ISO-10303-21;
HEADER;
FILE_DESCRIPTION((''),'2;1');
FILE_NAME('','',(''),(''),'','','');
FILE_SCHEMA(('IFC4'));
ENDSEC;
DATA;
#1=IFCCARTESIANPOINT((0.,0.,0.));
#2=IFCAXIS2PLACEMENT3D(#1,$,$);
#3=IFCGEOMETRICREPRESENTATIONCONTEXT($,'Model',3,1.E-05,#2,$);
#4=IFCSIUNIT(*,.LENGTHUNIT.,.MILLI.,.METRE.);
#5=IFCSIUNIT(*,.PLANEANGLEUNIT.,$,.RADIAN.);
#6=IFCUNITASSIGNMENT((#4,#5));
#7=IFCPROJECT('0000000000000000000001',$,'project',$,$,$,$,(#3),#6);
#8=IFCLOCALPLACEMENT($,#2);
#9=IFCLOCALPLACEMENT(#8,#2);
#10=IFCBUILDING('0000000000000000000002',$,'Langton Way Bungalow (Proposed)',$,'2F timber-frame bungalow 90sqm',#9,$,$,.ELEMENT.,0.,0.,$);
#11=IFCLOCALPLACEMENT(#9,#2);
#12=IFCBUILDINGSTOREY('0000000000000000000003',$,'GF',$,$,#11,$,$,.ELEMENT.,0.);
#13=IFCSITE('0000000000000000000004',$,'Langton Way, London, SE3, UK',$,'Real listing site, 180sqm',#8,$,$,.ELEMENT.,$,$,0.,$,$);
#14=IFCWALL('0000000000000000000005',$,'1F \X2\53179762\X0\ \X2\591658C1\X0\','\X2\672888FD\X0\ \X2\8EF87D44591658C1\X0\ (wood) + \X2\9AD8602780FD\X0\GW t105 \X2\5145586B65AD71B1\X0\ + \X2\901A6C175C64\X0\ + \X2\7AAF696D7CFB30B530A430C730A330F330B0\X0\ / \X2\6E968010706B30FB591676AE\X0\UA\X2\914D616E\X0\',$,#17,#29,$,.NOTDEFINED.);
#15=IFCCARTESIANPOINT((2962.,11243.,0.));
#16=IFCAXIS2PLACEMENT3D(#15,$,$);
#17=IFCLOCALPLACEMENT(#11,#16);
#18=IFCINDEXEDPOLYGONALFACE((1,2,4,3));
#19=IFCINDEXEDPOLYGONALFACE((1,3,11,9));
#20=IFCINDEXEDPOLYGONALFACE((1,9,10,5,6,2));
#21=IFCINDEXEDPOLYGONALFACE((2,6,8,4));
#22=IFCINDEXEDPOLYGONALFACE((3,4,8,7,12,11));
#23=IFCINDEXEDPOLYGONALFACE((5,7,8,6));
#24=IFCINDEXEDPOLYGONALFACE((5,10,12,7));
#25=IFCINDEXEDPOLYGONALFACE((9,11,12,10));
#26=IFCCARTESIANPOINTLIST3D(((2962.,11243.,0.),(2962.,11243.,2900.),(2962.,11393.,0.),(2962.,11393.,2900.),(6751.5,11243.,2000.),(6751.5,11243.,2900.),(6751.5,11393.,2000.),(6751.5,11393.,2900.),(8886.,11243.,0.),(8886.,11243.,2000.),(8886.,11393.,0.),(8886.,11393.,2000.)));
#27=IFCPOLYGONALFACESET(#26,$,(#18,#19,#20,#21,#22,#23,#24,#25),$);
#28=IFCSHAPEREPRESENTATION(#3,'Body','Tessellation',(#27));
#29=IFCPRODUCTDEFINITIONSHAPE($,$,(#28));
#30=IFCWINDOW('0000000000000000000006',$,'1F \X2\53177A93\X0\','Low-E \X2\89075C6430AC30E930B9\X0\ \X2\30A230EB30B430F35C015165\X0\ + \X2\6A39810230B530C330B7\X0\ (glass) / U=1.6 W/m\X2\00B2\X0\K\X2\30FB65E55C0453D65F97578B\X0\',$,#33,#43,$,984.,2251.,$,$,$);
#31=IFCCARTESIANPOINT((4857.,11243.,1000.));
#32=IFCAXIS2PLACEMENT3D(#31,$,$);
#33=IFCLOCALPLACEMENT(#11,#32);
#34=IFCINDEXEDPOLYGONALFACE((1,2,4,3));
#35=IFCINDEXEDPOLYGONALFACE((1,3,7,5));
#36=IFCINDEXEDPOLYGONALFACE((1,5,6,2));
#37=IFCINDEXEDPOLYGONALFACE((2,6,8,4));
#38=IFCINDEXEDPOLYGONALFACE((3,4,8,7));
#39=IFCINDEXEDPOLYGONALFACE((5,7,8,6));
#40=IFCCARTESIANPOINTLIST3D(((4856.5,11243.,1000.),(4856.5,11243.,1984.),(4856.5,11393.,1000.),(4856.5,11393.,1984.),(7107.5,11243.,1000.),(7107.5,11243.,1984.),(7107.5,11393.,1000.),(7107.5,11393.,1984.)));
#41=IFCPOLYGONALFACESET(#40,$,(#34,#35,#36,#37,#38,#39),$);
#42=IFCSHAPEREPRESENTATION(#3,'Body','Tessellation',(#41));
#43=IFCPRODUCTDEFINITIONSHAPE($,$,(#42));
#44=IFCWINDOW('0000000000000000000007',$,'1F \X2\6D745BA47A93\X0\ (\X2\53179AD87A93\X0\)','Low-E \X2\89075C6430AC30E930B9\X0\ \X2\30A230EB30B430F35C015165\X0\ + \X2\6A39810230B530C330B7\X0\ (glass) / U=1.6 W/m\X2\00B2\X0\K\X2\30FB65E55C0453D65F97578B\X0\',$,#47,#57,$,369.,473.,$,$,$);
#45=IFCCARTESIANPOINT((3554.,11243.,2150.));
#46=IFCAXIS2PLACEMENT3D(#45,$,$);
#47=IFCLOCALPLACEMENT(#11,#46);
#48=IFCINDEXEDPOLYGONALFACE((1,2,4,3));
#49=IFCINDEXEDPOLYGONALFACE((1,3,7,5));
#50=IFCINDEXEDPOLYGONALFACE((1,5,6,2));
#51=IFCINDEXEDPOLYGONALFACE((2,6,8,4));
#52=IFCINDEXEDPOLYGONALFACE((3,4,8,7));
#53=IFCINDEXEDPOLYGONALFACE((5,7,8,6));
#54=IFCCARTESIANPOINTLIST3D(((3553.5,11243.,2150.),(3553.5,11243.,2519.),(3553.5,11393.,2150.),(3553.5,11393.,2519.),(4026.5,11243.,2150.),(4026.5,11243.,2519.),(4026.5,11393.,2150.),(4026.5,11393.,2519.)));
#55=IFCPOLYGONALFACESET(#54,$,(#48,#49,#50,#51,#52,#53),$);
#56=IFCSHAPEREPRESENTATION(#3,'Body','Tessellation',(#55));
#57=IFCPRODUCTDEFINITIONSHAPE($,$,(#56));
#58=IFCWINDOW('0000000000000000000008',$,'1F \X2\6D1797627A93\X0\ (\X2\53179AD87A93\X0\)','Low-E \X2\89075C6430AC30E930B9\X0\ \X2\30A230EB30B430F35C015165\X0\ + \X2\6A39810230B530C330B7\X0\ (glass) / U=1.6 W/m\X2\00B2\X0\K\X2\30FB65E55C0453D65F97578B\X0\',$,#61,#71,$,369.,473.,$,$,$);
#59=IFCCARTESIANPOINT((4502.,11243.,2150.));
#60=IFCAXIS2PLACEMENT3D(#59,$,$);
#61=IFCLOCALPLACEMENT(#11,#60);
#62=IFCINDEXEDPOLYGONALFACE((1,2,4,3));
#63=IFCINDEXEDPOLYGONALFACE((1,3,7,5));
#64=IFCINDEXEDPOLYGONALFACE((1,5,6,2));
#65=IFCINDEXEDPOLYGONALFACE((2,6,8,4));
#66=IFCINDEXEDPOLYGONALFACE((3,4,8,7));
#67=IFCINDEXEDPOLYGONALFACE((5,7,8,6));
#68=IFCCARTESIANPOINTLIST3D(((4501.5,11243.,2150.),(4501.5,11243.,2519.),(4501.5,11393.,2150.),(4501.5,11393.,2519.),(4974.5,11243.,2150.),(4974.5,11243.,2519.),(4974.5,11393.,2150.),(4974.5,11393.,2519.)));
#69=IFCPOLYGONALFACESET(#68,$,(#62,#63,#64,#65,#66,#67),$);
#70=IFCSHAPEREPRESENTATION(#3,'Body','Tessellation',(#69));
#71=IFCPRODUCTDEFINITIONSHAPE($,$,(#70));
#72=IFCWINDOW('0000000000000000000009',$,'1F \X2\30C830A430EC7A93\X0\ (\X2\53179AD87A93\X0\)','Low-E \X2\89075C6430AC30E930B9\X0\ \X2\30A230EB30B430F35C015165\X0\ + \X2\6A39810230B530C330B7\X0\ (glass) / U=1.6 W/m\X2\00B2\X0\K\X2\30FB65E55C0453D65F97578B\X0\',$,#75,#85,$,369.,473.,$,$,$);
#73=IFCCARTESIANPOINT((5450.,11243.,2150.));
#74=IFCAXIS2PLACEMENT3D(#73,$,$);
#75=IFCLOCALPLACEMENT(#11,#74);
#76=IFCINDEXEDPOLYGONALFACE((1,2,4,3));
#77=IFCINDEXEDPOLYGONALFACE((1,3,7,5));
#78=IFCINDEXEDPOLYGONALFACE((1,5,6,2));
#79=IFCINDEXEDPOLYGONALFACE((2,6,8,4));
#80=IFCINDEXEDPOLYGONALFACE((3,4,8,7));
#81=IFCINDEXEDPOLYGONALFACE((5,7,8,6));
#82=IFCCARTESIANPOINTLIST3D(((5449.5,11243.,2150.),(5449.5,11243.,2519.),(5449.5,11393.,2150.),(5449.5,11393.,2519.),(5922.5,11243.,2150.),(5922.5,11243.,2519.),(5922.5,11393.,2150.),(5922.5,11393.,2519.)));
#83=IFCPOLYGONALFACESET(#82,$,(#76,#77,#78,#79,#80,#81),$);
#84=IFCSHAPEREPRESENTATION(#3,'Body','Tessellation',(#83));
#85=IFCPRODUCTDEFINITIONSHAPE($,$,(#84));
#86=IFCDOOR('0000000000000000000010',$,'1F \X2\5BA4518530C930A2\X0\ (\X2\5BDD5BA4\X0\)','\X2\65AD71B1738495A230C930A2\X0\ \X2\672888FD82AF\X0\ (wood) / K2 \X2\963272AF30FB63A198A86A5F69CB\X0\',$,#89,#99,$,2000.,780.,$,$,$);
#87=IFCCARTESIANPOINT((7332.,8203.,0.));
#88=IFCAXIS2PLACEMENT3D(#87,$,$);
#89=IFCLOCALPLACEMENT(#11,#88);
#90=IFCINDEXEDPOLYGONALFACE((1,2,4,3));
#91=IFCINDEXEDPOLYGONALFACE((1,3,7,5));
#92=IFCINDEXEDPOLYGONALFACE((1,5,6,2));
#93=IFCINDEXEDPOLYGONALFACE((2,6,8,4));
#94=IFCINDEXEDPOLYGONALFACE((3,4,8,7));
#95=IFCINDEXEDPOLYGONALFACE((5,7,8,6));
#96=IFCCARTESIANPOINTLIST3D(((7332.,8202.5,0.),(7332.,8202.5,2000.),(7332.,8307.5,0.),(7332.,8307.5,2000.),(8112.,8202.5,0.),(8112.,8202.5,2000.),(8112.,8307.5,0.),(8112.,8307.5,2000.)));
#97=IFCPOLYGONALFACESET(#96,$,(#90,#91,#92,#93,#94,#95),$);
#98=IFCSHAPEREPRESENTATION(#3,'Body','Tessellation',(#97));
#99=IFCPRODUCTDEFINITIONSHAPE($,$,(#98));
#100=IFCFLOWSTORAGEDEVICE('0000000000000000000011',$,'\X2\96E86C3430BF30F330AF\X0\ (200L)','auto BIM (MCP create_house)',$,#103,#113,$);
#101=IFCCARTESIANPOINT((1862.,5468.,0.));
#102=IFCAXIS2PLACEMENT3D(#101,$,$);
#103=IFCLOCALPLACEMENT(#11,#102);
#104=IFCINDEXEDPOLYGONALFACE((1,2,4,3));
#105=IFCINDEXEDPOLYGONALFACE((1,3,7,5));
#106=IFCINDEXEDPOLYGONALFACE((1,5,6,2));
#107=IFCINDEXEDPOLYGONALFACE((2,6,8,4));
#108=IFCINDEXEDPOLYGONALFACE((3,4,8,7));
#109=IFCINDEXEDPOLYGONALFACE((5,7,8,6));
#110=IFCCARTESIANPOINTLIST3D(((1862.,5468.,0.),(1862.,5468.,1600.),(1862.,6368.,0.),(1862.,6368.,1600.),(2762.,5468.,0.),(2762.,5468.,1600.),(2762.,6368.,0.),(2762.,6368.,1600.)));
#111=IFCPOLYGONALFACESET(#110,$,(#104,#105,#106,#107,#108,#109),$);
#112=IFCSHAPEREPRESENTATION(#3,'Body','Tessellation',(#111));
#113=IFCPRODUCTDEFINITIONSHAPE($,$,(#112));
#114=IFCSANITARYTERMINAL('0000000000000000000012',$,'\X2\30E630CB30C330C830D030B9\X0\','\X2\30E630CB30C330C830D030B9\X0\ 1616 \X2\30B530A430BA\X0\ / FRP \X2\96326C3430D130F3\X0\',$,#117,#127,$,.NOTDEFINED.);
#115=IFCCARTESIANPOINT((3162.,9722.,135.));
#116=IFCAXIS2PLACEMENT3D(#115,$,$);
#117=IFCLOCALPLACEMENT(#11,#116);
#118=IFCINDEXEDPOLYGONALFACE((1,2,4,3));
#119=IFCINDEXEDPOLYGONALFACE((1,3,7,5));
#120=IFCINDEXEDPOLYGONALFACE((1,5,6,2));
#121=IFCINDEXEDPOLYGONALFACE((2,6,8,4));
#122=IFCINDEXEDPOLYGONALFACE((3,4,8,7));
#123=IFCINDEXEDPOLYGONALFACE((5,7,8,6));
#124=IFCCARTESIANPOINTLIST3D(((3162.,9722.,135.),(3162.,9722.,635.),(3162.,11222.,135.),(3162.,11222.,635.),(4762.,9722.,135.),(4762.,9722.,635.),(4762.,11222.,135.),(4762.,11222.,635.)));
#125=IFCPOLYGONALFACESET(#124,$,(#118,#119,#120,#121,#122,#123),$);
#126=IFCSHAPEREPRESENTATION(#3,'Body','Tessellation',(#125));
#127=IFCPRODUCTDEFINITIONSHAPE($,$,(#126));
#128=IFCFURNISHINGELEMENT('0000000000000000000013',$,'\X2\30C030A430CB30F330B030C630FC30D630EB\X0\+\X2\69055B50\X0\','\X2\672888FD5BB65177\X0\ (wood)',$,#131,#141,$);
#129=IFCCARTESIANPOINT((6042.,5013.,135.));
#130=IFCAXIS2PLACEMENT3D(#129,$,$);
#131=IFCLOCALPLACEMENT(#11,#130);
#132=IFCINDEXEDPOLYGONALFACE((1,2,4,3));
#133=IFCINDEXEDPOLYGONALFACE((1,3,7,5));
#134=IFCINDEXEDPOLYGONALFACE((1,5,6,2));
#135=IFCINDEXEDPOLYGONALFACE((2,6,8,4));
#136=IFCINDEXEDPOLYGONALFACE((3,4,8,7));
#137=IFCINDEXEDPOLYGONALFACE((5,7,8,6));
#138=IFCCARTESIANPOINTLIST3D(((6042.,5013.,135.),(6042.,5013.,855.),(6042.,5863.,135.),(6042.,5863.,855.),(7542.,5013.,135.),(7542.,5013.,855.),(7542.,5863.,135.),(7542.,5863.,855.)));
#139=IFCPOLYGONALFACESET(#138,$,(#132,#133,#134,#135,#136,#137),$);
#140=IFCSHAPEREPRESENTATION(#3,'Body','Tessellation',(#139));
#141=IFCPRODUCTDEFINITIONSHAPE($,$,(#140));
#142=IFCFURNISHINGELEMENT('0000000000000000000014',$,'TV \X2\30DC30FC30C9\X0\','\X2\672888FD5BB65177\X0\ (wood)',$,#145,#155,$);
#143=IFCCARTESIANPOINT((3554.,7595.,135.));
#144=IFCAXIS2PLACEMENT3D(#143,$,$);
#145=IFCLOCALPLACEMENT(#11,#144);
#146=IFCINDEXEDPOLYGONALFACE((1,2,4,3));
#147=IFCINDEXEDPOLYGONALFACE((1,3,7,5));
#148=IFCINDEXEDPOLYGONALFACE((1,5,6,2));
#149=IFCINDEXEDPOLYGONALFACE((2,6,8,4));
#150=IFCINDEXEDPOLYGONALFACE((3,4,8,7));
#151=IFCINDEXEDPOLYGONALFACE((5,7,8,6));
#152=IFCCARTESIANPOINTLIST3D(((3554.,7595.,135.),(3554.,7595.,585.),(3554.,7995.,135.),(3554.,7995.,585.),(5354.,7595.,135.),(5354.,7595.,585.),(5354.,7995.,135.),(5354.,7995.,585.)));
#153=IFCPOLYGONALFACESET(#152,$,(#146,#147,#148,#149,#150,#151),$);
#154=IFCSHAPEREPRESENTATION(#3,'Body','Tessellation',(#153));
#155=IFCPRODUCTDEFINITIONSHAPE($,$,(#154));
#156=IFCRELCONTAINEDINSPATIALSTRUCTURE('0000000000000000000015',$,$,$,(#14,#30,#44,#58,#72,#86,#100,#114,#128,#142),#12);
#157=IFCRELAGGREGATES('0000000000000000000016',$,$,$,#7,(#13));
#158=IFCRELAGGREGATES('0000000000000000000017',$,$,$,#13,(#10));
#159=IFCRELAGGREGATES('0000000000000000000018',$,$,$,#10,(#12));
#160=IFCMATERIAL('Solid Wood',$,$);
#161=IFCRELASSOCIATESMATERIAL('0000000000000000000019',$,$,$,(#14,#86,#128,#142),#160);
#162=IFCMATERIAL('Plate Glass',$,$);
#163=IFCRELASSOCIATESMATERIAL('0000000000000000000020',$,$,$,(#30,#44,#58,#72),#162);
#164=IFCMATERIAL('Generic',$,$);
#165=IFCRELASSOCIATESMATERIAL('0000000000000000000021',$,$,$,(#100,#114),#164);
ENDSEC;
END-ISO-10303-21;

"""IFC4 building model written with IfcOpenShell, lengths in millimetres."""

from ifc_helpers import new_model, si_unit, frame, frame_2d, origin, place, context, project, spatial, rectangle, extrude, material, element, fill, save


model = new_model("IFC4")

# Units and contexts
model_context = context("Model", 3, precision=1e-05, world=origin())
ifc_project = project(units=[si_unit("LENGTHUNIT", "METRE", prefix="MILLI"), si_unit("PLANEANGLEUNIT", "RADIAN")], contexts=[model_context])

# Site, building, storey
site_placement = place(None, origin())
site = spatial("IfcSite", under=ifc_project, at=site_placement, Name="Langton Way, London, SE3, UK", ObjectType="Real listing site, 180sqm", CompositionType="ELEMENT", RefElevation=0.0)
building_placement = place(site_placement, origin())
building = spatial("IfcBuilding", under=site, at=building_placement, Name="Langton Way Bungalow (Proposed)", ObjectType="2F timber-frame bungalow 90sqm", CompositionType="ELEMENT", ElevationOfRefHeight=0.0, ElevationOfTerrain=0.0)
storey_placement = place(building_placement, origin())
storey = spatial("IfcBuildingStorey", under=building, at=storey_placement, Name="GF", CompositionType="ELEMENT", Elevation=0.0)

# Wall, openings, windows
ifc_material_1 = material(Name="Solid Wood")
wall_1_placement = place(storey_placement, frame((2962.0, 11243.0, 0.0)))
wall_1 = element("IfcWall", 1, at=wall_1_placement, inside=storey, material=ifc_material_1, Name="1F 北面 外壁", Description="木製 軸組外壁 (wood) + 高性能GW t105 充填断熱 + 通気層 + 窯業系サイディング / 準耐火・外皮UA配慮", PredefinedType="NOTDEFINED", context=model_context, shape_type="SweptSolid", body=[
    extrude(rectangle(XDim=5924.0, YDim=150.0, at=frame_2d((2962.0, 75.0))), frame((2962.0, 11243.0, 0.0)), (0.0, 0.0, 1.0), 2900.0),
])
opening_1_placement = place(storey_placement, frame((4857.0, 11243.0, 1000.0)))
opening_1 = element("IfcOpeningElement", 2, at=opening_1_placement, cuts=wall_1, PredefinedType="NOTDEFINED", context=model_context, shape_type="SweptSolid", body=[
    extrude(rectangle(XDim=2251.0, YDim=150.0, at=frame_2d((1125.0, 75.0))), frame((4857.0, 11243.0, 1000.0)), (0.0, 0.0, 1.0), 984.0),
])
opening_2_placement = place(storey_placement, frame((3554.0, 11243.0, 2150.0)))
opening_2 = element("IfcOpeningElement", 3, at=opening_2_placement, cuts=wall_1, PredefinedType="NOTDEFINED", context=model_context, shape_type="SweptSolid", body=[
    extrude(rectangle(XDim=473.0, YDim=150.0, at=frame_2d((236.0, 75.0))), frame((3554.0, 11243.0, 2150.0)), (0.0, 0.0, 1.0), 369.0),
])
opening_3_placement = place(storey_placement, frame((4502.0, 11243.0, 2150.0)))
opening_3 = element("IfcOpeningElement", 4, at=opening_3_placement, cuts=wall_1, PredefinedType="NOTDEFINED", context=model_context, shape_type="SweptSolid", body=[
    extrude(rectangle(XDim=473.0, YDim=150.0, at=frame_2d((236.0, 75.0))), frame((4502.0, 11243.0, 2150.0)), (0.0, 0.0, 1.0), 369.0),
])
opening_4_placement = place(storey_placement, frame((5450.0, 11243.0, 2150.0)))
opening_4 = element("IfcOpeningElement", 5, at=opening_4_placement, cuts=wall_1, PredefinedType="NOTDEFINED", context=model_context, shape_type="SweptSolid", body=[
    extrude(rectangle(XDim=473.0, YDim=150.0, at=frame_2d((236.0, 75.0))), frame((5450.0, 11243.0, 2150.0)), (0.0, 0.0, 1.0), 369.0),
])
ifc_material_2 = material(Name="Plate Glass")
window_1_placement = place(storey_placement, frame((4857.0, 11243.0, 1000.0)))
window_1 = element("IfcWindow", 6, at=window_1_placement, inside=storey, material=ifc_material_2, Name="1F 北窓", Description="Low-E 複層ガラス アルゴン封入 + 樹脂サッシ (glass) / U=1.6 W/m²K・日射取得型", OverallHeight=984.0, OverallWidth=2251.0, context=model_context, shape_type="SweptSolid", body=[
    extrude(rectangle(XDim=2251.0, YDim=150.0, at=frame_2d((1125.0, 75.0))), frame((4857.0, 11243.0, 1000.0)), (0.0, 0.0, 1.0), 984.0),
])
fill(opening_1, window_1)
window_2_placement = place(storey_placement, frame((3554.0, 11243.0, 2150.0)))
window_2 = element("IfcWindow", 7, at=window_2_placement, inside=storey, material=ifc_material_2, Name="1F 浴室窓 (北高窓)", Description="Low-E 複層ガラス アルゴン封入 + 樹脂サッシ (glass) / U=1.6 W/m²K・日射取得型", OverallHeight=369.0, OverallWidth=473.0, context=model_context, shape_type="SweptSolid", body=[
    extrude(rectangle(XDim=473.0, YDim=150.0, at=frame_2d((236.0, 75.0))), frame((3554.0, 11243.0, 2150.0)), (0.0, 0.0, 1.0), 369.0),
])
fill(opening_2, window_2)
window_3_placement = place(storey_placement, frame((4502.0, 11243.0, 2150.0)))
window_3 = element("IfcWindow", 8, at=window_3_placement, inside=storey, material=ifc_material_2, Name="1F 洗面窓 (北高窓)", Description="Low-E 複層ガラス アルゴン封入 + 樹脂サッシ (glass) / U=1.6 W/m²K・日射取得型", OverallHeight=369.0, OverallWidth=473.0, context=model_context, shape_type="SweptSolid", body=[
    extrude(rectangle(XDim=473.0, YDim=150.0, at=frame_2d((236.0, 75.0))), frame((4502.0, 11243.0, 2150.0)), (0.0, 0.0, 1.0), 369.0),
])
fill(opening_3, window_3)
window_4_placement = place(storey_placement, frame((5450.0, 11243.0, 2150.0)))
window_4 = element("IfcWindow", 9, at=window_4_placement, inside=storey, material=ifc_material_2, Name="1F トイレ窓 (北高窓)", Description="Low-E 複層ガラス アルゴン封入 + 樹脂サッシ (glass) / U=1.6 W/m²K・日射取得型", OverallHeight=369.0, OverallWidth=473.0, context=model_context, shape_type="SweptSolid", body=[
    extrude(rectangle(XDim=473.0, YDim=150.0, at=frame_2d((236.0, 75.0))), frame((5450.0, 11243.0, 2150.0)), (0.0, 0.0, 1.0), 369.0),
])
fill(opening_4, window_4)

# Door
door_1_placement = place(storey_placement, frame((7332.0, 8203.0, 0.0)))
element("IfcDoor", 10, at=door_1_placement, inside=storey, material=ifc_material_1, Name="1F 室内ドア (寝室)", Description="断熱玄関ドア 木製芯 (wood) / K2 防犯・採風機構", OverallHeight=2000.0, OverallWidth=780.0, context=model_context, shape_type="SweptSolid", body=[
    extrude(rectangle(XDim=780.0, YDim=105.0, at=frame_2d((390.0, 52.0))), frame((7332.0, 8203.0, 0.0)), (0.0, 0.0, 1.0), 2000.0),
])

# Flow storage device
ifc_material_3 = material(Name="Generic")
flow_storage_device_placement = place(storey_placement, frame((1862.0, 5468.0, 0.0)))
element("IfcFlowStorageDevice", 11, at=flow_storage_device_placement, inside=storey, material=ifc_material_3, Name="雨水タンク (200L)", Description="auto BIM (MCP create_house)", context=model_context, shape_type="SweptSolid", body=[
    extrude(rectangle(XDim=900.0, YDim=900.0, at=frame_2d((450.0, 450.0))), frame((1862.0, 5468.0, 0.0)), (0.0, 0.0, 1.0), 1600.0),
])

# Sanitary terminal
sanitary_terminal_placement = place(storey_placement, frame((3162.0, 9722.0, 135.0)))
element("IfcSanitaryTerminal", 12, at=sanitary_terminal_placement, inside=storey, material=ifc_material_3, Name="ユニットバス", Description="ユニットバス 1616 サイズ / FRP 防水パン", PredefinedType="NOTDEFINED", context=model_context, shape_type="SweptSolid", body=[
    extrude(rectangle(XDim=1600.0, YDim=1500.0, at=frame_2d((800.0, 750.0))), frame((3162.0, 9722.0, 135.0)), (0.0, 0.0, 1.0), 500.0),
])

# Furnishing elements
furnishing_1_placement = place(storey_placement, frame((6042.0, 5013.0, 135.0)))
element("IfcFurnishingElement", 13, at=furnishing_1_placement, inside=storey, material=ifc_material_1, Name="ダイニングテーブル+椅子", Description="木製家具 (wood)", context=model_context, shape_type="SweptSolid", body=[
    extrude(rectangle(XDim=1500.0, YDim=850.0, at=frame_2d((750.0, 425.0))), frame((6042.0, 5013.0, 135.0)), (0.0, 0.0, 1.0), 720.0),
])
furnishing_2_placement = place(storey_placement, frame((3554.0, 7595.0, 135.0)))
element("IfcFurnishingElement", 14, at=furnishing_2_placement, inside=storey, material=ifc_material_1, Name="TV ボード", Description="木製家具 (wood)", context=model_context, shape_type="SweptSolid", body=[
    extrude(rectangle(XDim=1800.0, YDim=400.0, at=frame_2d((900.0, 200.0))), frame((3554.0, 7595.0, 135.0)), (0.0, 0.0, 1.0), 450.0),
])

save(model, "model.ifc")
